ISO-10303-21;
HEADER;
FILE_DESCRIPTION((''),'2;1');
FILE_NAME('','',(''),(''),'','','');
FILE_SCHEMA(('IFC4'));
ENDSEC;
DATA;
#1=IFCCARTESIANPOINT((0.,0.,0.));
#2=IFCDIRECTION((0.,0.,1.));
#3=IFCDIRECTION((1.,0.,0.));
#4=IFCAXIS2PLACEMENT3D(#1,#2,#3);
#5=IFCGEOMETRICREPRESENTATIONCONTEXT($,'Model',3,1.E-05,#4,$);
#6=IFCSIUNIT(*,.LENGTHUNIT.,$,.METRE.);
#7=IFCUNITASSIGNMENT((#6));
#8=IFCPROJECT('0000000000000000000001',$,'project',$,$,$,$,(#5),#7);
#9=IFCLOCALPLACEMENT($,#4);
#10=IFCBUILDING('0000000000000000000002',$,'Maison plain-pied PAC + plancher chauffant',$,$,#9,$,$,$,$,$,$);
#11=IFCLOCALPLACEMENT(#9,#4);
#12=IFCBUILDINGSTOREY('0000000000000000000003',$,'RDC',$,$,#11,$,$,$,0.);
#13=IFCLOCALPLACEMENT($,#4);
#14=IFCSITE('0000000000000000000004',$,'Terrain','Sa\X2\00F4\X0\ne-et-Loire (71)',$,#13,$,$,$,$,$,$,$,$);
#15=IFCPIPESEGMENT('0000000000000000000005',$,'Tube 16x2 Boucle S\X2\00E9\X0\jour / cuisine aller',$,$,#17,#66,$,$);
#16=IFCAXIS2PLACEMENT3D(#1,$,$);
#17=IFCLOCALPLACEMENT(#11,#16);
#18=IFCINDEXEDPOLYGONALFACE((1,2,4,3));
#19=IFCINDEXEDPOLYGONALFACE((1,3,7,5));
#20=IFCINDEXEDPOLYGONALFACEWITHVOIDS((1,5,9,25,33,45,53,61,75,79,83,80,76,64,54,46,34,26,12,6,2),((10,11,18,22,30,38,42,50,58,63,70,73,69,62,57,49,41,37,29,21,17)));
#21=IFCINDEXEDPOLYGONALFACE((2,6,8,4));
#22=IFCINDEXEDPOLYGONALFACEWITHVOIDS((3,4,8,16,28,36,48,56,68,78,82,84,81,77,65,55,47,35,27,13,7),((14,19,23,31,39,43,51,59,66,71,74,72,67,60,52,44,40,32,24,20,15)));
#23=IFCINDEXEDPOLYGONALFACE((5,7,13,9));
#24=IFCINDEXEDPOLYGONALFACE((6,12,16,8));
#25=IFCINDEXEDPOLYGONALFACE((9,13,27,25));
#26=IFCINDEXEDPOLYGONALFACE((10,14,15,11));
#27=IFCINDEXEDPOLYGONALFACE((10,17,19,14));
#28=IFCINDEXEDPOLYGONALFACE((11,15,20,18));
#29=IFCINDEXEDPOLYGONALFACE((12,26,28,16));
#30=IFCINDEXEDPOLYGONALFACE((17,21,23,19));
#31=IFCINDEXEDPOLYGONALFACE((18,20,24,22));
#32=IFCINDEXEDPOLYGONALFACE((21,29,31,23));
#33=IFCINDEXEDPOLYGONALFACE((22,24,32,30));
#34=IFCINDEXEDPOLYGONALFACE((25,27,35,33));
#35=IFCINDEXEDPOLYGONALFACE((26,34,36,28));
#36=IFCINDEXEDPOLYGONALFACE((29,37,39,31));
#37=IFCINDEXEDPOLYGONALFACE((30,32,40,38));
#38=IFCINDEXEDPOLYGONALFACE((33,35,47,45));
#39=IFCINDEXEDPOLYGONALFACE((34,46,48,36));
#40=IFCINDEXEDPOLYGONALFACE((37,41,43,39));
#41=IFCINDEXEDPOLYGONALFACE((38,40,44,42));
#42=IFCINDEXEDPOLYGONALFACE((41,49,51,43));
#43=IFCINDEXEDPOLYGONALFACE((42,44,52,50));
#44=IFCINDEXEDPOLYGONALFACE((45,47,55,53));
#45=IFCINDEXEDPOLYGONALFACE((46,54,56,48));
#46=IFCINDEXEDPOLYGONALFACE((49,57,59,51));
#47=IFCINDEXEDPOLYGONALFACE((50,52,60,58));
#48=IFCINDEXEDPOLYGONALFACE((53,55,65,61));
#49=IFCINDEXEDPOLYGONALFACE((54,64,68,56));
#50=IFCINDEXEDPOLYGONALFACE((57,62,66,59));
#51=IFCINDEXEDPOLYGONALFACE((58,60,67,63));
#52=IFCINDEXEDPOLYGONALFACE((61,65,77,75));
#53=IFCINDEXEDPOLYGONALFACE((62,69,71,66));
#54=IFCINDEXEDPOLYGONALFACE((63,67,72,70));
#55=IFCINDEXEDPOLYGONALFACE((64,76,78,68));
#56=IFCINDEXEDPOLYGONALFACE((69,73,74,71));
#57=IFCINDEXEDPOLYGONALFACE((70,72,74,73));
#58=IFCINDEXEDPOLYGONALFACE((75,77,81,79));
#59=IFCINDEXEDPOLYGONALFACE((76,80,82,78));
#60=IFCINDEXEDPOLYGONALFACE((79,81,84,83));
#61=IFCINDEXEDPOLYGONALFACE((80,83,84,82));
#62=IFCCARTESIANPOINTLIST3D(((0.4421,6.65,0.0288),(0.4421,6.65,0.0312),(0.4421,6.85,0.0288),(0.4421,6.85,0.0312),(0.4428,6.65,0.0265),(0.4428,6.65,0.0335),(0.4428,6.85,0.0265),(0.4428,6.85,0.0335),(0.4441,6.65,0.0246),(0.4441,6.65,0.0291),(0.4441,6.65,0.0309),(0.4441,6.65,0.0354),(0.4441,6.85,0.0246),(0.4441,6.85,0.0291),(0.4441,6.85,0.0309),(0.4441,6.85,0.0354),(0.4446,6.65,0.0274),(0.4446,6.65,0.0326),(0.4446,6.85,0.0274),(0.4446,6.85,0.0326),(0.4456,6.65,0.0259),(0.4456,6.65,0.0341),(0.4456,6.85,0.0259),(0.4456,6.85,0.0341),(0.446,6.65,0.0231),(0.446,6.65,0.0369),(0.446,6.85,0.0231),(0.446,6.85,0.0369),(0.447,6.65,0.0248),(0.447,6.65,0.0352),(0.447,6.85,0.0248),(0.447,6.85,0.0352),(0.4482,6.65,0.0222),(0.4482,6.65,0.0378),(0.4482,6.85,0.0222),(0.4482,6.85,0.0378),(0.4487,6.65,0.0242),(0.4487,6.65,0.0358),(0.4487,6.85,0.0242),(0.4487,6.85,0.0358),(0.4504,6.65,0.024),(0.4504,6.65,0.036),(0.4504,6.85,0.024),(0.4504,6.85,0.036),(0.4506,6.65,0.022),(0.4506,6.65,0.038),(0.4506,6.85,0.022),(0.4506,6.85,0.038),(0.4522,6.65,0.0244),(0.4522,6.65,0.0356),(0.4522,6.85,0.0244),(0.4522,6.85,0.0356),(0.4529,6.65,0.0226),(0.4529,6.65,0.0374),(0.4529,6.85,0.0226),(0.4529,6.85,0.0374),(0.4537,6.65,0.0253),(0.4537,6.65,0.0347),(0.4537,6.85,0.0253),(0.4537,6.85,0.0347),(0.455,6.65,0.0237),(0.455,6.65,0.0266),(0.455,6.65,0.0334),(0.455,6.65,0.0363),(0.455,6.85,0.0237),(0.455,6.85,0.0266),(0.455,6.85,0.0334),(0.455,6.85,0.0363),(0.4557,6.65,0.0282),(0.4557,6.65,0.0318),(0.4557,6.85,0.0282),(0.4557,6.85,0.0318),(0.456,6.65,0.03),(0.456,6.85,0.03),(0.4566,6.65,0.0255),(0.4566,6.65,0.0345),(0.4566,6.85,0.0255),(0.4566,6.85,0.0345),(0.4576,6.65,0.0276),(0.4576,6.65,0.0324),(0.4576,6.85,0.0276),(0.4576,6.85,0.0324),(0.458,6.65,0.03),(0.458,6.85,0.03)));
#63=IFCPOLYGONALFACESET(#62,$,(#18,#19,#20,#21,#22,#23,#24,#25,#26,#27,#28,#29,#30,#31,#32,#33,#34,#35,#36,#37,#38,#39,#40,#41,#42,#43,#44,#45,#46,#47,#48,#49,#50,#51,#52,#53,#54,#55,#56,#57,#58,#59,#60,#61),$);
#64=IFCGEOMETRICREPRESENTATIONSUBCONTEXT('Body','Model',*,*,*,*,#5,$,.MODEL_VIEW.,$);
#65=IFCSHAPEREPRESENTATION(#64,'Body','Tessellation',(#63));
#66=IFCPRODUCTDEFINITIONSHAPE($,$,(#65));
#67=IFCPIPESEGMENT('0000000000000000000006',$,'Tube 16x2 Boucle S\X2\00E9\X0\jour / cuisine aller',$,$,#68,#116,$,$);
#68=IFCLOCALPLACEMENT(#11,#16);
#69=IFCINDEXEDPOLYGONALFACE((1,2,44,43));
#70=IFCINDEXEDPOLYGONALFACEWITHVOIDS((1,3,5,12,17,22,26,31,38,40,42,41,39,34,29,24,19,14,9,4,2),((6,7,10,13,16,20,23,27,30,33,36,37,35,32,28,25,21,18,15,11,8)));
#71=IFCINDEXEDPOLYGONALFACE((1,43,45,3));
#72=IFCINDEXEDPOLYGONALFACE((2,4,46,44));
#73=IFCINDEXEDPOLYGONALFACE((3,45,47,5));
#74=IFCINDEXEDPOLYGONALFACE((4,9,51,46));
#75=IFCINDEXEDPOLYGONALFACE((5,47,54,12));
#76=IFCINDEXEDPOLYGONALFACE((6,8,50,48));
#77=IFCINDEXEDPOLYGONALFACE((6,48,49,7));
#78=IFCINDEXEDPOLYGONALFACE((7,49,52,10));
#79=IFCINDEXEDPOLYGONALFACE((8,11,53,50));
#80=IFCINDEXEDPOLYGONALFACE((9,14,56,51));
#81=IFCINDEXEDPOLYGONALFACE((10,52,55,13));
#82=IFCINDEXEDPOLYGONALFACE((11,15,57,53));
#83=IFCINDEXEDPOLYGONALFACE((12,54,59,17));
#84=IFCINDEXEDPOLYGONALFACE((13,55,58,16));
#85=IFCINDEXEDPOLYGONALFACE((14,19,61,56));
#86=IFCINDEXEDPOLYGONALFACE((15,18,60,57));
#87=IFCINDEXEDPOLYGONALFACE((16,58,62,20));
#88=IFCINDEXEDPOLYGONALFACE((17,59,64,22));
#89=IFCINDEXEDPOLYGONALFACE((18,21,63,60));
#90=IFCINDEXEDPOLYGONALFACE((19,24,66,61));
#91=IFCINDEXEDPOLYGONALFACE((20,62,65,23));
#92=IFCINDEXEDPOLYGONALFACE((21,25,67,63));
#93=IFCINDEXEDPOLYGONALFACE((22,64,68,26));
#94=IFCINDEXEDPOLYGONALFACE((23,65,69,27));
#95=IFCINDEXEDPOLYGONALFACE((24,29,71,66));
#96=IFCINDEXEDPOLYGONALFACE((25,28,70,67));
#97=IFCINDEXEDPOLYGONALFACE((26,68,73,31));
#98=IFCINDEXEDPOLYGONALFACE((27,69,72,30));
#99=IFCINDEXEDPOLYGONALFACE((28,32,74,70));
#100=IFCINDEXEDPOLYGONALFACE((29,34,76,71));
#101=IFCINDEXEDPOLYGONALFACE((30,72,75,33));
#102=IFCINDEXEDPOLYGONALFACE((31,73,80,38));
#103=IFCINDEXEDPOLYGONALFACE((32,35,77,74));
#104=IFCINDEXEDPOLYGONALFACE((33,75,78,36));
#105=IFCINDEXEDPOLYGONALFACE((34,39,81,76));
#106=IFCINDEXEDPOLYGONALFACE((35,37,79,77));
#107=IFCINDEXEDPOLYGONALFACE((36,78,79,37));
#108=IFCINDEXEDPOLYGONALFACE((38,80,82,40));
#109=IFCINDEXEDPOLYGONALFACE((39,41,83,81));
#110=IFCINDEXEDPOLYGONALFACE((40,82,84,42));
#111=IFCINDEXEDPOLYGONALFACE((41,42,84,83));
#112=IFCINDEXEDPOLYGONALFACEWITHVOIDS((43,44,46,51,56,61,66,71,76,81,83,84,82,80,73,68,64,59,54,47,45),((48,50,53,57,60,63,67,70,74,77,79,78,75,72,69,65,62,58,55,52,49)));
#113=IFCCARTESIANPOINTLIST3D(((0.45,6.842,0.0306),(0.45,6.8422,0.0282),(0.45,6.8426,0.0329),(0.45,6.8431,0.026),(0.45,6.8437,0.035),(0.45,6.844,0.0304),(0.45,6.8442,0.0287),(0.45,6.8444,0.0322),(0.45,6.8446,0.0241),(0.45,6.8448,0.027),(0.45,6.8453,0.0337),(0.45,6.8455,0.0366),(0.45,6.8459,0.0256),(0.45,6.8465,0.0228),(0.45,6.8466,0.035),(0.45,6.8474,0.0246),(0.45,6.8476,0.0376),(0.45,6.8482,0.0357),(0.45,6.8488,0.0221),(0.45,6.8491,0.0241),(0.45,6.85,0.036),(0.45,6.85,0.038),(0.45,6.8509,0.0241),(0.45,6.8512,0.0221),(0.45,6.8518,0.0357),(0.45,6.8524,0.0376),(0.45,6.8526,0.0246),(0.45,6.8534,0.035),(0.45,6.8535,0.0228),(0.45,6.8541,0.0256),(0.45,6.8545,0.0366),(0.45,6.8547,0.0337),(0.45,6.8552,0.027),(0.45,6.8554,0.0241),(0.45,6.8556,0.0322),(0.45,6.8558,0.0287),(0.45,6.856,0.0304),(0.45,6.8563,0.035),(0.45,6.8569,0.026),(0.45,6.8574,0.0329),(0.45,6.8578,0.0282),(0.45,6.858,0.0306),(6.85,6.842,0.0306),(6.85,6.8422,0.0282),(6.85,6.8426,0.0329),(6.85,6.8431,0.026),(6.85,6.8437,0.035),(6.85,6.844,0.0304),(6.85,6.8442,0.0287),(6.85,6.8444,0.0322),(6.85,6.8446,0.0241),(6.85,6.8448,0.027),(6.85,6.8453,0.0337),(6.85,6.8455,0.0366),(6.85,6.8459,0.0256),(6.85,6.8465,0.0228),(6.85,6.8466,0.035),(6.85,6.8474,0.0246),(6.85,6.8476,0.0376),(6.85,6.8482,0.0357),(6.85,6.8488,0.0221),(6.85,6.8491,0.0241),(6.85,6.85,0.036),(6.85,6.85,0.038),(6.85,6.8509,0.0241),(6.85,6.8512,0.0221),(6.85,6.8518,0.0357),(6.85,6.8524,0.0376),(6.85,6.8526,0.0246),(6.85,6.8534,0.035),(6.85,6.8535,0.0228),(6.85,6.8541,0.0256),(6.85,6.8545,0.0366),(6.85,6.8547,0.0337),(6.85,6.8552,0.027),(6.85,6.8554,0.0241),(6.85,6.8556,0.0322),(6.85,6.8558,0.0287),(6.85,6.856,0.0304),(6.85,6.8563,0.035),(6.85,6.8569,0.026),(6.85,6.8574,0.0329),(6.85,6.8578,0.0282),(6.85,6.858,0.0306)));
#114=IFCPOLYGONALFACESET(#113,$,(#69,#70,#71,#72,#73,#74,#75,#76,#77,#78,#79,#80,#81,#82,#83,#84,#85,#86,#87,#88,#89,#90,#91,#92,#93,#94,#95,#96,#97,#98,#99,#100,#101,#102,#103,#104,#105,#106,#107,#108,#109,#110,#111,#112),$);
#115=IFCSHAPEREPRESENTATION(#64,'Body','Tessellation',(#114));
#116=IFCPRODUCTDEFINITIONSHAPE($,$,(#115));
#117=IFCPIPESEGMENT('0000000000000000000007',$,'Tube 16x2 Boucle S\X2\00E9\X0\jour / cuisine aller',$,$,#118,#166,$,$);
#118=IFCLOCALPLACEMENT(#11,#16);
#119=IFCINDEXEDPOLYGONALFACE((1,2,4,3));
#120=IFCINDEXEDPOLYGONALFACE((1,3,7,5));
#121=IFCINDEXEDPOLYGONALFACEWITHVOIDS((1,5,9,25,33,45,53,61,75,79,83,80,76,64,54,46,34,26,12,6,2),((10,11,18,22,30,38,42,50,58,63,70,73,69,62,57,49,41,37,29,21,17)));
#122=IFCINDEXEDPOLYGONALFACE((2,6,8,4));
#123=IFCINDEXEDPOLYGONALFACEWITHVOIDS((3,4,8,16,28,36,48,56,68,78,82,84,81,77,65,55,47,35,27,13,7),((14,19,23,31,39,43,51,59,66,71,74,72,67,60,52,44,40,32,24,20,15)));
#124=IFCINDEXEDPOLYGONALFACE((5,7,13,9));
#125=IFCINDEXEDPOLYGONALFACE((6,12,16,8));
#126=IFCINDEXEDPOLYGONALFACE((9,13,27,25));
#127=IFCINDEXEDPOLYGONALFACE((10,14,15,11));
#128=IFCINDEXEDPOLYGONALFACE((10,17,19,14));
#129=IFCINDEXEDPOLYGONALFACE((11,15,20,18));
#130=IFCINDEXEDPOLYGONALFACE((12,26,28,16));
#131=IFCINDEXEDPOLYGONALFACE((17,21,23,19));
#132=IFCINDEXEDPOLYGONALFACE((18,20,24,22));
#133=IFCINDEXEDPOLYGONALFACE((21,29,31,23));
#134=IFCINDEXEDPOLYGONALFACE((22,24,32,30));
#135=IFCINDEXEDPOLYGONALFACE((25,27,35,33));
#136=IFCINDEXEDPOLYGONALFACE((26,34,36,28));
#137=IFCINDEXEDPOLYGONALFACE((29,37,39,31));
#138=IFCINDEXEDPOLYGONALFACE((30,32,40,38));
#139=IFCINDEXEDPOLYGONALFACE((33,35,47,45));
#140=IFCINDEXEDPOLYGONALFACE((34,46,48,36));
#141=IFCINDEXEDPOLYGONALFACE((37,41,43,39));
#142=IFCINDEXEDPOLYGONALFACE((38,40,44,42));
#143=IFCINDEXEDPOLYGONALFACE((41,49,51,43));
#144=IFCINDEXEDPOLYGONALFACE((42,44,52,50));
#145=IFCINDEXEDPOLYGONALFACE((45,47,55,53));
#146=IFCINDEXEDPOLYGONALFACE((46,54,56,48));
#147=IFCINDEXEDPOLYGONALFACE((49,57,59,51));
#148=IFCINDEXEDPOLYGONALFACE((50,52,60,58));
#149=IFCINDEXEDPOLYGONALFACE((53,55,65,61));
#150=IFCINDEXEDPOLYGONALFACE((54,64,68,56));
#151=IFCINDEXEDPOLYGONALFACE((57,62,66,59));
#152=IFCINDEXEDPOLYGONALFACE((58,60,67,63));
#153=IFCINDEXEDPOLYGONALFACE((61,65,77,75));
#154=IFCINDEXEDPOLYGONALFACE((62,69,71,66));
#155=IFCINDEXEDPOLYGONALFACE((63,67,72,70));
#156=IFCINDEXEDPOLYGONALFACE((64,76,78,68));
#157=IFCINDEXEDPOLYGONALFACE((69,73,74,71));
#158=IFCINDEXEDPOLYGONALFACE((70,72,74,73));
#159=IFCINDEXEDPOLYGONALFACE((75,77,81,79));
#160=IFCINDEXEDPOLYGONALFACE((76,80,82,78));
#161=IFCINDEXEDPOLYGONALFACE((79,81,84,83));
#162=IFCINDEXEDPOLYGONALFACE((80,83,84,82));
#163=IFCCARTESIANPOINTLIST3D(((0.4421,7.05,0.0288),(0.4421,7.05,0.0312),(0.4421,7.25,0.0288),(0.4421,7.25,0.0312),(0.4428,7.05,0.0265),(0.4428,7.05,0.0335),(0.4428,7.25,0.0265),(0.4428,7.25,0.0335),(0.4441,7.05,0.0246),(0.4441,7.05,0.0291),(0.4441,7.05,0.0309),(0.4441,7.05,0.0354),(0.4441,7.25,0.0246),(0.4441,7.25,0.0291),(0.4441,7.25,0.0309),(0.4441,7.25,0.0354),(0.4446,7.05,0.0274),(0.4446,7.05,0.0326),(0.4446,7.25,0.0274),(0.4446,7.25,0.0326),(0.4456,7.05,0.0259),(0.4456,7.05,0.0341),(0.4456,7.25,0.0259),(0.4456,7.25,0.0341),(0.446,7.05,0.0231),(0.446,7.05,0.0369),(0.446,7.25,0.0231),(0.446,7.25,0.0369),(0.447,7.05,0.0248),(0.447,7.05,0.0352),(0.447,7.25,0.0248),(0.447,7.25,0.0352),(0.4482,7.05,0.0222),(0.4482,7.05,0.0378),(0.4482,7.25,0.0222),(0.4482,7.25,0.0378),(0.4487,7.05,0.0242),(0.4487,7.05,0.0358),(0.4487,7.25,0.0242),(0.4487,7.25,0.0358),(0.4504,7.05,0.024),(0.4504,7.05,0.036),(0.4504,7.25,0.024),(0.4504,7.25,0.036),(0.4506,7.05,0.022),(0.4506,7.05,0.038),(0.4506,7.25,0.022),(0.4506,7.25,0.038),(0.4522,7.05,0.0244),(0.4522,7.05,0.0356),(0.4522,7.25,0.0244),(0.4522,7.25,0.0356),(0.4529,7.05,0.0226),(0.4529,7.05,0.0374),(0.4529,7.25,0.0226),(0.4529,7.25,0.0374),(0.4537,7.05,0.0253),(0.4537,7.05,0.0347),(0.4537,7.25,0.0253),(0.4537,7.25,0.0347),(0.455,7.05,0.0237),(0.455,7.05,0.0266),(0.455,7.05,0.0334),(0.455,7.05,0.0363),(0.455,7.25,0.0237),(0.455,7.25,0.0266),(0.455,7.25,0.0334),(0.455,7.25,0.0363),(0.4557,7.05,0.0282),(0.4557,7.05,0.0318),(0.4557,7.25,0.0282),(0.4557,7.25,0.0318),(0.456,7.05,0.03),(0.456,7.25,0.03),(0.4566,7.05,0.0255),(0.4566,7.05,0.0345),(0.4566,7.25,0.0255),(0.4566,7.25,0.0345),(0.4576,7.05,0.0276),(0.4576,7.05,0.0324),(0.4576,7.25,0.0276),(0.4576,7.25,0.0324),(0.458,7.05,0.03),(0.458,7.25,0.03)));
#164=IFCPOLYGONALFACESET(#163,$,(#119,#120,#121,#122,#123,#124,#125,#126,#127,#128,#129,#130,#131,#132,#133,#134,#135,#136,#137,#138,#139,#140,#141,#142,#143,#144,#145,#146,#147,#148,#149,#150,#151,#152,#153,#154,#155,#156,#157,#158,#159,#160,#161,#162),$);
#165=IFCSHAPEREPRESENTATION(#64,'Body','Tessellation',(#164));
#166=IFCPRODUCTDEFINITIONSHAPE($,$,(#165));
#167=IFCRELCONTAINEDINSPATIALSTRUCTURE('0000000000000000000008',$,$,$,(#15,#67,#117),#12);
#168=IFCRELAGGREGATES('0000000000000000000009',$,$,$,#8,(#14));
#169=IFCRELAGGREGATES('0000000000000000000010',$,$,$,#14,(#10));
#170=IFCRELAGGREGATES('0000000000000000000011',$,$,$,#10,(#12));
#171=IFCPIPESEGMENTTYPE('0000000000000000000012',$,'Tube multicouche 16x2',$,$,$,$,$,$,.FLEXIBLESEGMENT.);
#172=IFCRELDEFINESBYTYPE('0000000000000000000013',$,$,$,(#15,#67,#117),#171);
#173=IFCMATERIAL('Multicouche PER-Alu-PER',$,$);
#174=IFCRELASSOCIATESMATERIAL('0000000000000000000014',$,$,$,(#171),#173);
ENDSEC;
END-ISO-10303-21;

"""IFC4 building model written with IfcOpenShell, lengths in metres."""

from ifc_helpers import new_model, si_unit, frame, origin_with_axes, place, context, subcontext, project, spatial, hollow_circle, extrude, material, type_object, element, save


model = new_model("IFC4")

# Units and contexts
model_context = context("Model", 3, precision=1e-05, world=origin_with_axes())
body_context = subcontext(model_context, "Body", "Model", "MODEL_VIEW")
ifc_project = project(units=[si_unit("LENGTHUNIT", "METRE")], contexts=[model_context])

# Site, building, storey
site_placement = place(None, origin_with_axes())
site = spatial("IfcSite", under=ifc_project, at=site_placement, Name="Terrain", Description="Saône-et-Loire (71)")
building_placement = place(None, origin_with_axes())
building = spatial("IfcBuilding", under=site, at=building_placement, Name="Maison plain-pied PAC + plancher chauffant")
storey_placement = place(building_placement, origin_with_axes())
storey = spatial("IfcBuildingStorey", under=building, at=storey_placement, Name="RDC", Elevation=0.0)

# Pipe segments
ifc_material_1 = material(Name="Multicouche PER-Alu-PER")
pipe_segment_type_1 = type_object("IfcPipeSegmentType", Name="Tube multicouche 16x2", PredefinedType="FLEXIBLESEGMENT", material=ifc_material_1)
pipe_segment_1_placement = place(storey_placement, frame((0.45, 6.65, 0.03), z_axis=(0.0, 1.0, 0.0), x_axis=(1.0, 0.0, 0.0)))
element("IfcPipeSegment", 1, at=pipe_segment_1_placement, inside=storey, type_object=pipe_segment_type_1, Name="Tube 16x2 Boucle Séjour / cuisine aller", context=body_context, shape_type="SweptSolid", body=[
    extrude(hollow_circle(Radius=0.008, WallThickness=0.002), origin_with_axes(), (0.0, 0.0, 1.0), 0.2),
])
pipe_segment_2_placement = place(storey_placement, frame((0.45, 6.85, 0.03), z_axis=(1.0, 0.0, 0.0), x_axis=(0.0, 0.0, 1.0)))
element("IfcPipeSegment", 2, at=pipe_segment_2_placement, inside=storey, type_object=pipe_segment_type_1, Name="Tube 16x2 Boucle Séjour / cuisine aller", context=body_context, shape_type="SweptSolid", body=[
    extrude(hollow_circle(Radius=0.008, WallThickness=0.002), origin_with_axes(), (0.0, 0.0, 1.0), 6.4),
])
pipe_segment_3_placement = place(storey_placement, frame((0.45, 7.05, 0.03), z_axis=(0.0, 1.0, 0.0), x_axis=(1.0, 0.0, 0.0)))
element("IfcPipeSegment", 3, at=pipe_segment_3_placement, inside=storey, type_object=pipe_segment_type_1, Name="Tube 16x2 Boucle Séjour / cuisine aller", context=body_context, shape_type="SweptSolid", body=[
    extrude(hollow_circle(Radius=0.008, WallThickness=0.002), origin_with_axes(), (0.0, 0.0, 1.0), 0.2),
])

save(model, "model.ifc")
